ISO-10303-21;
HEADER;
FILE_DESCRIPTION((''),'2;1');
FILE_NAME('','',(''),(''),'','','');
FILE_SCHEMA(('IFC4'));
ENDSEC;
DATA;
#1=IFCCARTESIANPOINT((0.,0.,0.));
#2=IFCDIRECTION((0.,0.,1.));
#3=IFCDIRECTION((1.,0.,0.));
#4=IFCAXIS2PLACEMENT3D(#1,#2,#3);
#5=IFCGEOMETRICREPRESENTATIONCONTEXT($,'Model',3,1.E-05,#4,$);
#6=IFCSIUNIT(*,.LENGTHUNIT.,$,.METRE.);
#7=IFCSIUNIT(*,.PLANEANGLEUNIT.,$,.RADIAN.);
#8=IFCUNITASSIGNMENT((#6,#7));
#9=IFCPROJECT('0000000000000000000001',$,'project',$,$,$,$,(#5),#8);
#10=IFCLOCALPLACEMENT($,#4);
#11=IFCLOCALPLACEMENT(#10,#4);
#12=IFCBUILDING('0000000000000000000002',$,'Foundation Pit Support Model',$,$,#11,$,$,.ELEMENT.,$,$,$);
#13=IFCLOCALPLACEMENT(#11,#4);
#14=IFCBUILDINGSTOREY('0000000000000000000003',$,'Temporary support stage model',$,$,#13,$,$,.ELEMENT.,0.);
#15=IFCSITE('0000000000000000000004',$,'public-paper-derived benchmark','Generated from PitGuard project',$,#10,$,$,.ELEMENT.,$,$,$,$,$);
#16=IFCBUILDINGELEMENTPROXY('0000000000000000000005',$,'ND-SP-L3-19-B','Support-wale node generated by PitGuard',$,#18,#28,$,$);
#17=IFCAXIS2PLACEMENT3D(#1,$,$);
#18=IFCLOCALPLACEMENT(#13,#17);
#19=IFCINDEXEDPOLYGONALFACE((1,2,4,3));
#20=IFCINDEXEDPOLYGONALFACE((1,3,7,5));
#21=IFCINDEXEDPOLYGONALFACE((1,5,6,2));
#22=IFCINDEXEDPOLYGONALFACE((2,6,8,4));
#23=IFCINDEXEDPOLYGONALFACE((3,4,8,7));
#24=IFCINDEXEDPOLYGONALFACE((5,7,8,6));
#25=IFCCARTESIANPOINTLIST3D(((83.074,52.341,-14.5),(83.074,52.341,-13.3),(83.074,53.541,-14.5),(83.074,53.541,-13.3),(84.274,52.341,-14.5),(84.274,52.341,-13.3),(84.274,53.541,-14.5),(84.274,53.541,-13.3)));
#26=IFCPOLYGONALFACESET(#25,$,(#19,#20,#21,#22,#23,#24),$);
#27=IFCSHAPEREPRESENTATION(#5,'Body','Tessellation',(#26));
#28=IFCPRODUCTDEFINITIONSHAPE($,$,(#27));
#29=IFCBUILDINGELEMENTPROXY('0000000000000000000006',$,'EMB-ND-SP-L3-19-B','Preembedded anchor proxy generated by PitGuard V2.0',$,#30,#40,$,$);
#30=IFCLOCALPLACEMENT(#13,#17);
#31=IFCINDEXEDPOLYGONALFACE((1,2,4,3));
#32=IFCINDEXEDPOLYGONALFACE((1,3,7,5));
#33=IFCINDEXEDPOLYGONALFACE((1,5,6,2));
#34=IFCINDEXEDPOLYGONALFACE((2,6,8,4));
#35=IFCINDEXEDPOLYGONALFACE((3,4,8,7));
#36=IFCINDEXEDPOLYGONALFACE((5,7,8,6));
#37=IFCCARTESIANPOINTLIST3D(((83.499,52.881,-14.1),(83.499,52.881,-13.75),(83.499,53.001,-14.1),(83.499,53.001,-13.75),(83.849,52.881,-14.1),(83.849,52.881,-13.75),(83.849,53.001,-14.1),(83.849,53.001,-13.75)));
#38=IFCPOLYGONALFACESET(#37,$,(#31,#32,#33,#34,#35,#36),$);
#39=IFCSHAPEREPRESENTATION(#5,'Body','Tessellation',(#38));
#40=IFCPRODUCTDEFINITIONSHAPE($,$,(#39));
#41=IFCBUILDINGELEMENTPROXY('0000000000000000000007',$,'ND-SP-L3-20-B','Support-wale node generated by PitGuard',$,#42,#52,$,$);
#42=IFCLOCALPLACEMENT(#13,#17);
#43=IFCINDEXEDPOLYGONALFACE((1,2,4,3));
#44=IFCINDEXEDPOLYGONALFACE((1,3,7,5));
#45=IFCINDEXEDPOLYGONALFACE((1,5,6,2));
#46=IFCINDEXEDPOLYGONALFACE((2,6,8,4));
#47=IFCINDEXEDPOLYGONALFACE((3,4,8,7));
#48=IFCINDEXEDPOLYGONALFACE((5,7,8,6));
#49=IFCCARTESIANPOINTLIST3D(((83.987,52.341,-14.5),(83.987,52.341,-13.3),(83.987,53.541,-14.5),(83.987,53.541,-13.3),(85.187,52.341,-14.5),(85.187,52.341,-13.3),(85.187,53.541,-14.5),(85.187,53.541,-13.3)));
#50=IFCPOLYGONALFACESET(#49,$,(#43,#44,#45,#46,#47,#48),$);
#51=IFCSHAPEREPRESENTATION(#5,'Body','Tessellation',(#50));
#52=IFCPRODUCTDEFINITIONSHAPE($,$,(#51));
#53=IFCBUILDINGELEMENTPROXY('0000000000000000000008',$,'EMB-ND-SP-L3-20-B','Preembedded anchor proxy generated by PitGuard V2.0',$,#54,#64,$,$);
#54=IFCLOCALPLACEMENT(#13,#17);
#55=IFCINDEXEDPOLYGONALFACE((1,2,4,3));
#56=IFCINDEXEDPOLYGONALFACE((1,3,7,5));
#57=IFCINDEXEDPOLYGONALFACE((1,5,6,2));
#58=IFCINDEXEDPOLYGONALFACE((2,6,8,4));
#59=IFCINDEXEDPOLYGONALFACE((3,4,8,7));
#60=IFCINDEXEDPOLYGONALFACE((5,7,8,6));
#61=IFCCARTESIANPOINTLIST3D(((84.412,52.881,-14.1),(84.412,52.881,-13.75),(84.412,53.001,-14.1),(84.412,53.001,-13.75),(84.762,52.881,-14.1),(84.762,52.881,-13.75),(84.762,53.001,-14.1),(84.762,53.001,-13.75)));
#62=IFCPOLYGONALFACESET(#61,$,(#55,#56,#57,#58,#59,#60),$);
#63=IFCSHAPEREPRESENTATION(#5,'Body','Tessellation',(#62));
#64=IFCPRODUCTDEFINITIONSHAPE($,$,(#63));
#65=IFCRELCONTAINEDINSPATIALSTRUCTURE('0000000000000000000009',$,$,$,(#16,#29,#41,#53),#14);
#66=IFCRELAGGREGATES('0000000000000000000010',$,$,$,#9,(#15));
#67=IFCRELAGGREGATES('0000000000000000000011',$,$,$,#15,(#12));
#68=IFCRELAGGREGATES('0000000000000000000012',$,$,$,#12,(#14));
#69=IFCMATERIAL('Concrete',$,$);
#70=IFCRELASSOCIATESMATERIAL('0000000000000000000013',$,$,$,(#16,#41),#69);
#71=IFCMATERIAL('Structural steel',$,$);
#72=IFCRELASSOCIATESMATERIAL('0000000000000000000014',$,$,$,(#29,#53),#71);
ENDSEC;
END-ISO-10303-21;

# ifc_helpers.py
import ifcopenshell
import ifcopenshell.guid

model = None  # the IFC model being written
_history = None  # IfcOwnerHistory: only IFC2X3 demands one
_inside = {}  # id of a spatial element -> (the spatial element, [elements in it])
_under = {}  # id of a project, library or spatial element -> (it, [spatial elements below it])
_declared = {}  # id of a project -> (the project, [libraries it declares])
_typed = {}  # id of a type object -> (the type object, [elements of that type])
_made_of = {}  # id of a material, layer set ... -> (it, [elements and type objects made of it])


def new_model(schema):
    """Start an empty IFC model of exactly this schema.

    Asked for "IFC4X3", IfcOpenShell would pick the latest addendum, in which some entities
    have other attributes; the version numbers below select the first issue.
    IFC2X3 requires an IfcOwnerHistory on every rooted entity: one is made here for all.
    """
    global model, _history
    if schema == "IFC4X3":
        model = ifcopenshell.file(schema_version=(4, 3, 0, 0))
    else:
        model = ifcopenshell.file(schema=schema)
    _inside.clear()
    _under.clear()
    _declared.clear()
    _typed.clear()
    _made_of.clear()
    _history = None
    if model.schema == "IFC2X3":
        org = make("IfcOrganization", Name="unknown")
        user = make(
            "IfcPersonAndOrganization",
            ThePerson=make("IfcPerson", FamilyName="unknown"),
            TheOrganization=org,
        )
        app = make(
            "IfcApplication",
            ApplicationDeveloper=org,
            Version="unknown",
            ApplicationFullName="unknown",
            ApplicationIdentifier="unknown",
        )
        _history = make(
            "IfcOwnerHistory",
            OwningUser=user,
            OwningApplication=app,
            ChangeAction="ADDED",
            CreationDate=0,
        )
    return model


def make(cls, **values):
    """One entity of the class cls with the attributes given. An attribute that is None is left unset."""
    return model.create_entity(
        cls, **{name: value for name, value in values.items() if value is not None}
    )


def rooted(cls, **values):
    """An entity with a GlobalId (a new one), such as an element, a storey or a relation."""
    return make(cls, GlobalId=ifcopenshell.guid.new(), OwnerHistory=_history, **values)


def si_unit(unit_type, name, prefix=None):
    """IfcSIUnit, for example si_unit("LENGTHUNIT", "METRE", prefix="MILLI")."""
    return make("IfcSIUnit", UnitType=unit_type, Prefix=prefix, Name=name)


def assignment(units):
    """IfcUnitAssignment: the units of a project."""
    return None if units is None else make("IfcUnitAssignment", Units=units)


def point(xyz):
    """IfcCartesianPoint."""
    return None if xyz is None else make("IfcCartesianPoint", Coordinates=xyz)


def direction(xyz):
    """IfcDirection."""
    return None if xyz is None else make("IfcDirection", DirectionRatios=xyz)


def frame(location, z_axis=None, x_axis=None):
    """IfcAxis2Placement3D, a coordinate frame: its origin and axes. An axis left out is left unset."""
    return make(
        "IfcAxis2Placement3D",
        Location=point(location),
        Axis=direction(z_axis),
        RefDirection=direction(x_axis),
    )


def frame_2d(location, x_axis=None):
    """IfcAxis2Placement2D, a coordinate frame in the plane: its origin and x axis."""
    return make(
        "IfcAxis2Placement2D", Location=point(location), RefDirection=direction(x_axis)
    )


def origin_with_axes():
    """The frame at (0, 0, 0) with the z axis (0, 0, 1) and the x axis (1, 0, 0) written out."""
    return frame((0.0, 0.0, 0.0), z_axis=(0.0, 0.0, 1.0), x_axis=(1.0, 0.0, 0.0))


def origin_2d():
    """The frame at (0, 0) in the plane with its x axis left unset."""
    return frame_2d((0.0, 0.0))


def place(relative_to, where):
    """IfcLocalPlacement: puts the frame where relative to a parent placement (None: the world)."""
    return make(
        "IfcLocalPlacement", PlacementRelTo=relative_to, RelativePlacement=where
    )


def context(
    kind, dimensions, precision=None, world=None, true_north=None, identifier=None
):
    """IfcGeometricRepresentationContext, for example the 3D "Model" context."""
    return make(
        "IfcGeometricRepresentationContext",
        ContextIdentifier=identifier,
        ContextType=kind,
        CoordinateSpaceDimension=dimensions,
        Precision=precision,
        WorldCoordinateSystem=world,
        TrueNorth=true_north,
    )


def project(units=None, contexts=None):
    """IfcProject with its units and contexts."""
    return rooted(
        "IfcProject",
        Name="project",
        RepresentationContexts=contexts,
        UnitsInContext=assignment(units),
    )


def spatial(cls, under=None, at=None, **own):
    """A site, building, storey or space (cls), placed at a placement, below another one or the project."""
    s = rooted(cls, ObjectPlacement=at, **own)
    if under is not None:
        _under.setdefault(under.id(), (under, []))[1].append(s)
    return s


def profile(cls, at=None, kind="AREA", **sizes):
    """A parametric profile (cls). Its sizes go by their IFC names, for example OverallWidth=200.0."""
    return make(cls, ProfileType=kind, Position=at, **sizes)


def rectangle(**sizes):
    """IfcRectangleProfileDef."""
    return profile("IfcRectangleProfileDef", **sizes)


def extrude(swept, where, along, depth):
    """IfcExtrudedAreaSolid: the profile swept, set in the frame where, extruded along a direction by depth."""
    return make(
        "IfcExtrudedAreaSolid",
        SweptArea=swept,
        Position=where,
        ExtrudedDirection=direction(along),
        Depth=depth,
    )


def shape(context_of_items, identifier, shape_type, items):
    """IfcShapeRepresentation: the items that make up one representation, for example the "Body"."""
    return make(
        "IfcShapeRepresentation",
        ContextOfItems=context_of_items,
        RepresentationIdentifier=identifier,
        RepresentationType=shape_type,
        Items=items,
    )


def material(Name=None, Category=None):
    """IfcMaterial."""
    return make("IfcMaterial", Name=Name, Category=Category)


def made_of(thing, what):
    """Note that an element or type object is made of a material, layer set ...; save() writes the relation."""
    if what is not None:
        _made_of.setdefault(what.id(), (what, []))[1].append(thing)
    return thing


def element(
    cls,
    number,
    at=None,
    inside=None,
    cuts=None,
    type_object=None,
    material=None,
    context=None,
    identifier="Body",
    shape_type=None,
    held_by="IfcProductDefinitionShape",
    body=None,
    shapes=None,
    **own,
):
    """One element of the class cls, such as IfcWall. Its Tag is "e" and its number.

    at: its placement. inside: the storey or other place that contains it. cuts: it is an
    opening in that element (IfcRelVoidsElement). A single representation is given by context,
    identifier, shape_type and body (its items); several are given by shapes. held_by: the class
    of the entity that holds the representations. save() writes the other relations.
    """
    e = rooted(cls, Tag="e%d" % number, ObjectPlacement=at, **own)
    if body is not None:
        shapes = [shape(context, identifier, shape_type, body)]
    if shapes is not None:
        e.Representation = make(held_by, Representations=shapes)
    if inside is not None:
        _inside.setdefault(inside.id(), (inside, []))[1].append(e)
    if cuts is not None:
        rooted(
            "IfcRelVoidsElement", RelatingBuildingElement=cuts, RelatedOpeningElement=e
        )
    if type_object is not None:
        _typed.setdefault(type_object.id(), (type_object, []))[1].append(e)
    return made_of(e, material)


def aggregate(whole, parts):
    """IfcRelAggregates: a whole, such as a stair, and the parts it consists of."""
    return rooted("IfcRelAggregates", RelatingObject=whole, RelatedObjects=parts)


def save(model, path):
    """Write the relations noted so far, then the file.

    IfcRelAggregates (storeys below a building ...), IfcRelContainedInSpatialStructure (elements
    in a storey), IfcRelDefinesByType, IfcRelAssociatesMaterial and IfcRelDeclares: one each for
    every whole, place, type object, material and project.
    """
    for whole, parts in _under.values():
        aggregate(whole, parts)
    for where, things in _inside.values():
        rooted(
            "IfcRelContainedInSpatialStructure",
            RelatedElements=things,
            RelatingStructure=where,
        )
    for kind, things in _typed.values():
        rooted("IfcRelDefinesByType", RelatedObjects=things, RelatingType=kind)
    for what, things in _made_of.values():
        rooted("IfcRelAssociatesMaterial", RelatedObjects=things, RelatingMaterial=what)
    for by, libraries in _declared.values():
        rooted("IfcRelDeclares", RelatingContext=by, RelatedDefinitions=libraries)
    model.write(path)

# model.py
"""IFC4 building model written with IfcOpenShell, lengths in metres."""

from ifc_helpers import new_model, si_unit, frame, origin_with_axes, origin_2d, place, context, project, spatial, rectangle, extrude, material, element, save


model = new_model("IFC4")

# Units and contexts
model_context = context("Model", 3, precision=1e-05, world=origin_with_axes())
ifc_project = project(units=[si_unit("LENGTHUNIT", "METRE"), si_unit("PLANEANGLEUNIT", "RADIAN")], contexts=[model_context])

# Site, building, storey
site_placement = place(None, origin_with_axes())
site = spatial("IfcSite", under=ifc_project, at=site_placement, Name="public-paper-derived benchmark", Description="Generated from PitGuard project", CompositionType="ELEMENT")
building_placement = place(site_placement, origin_with_axes())
building = spatial("IfcBuilding", under=site, at=building_placement, Name="Foundation Pit Support Model", CompositionType="ELEMENT")
storey_placement = place(building_placement, origin_with_axes())
storey = spatial("IfcBuildingStorey", under=building, at=storey_placement, Name="Temporary support stage model", CompositionType="ELEMENT", Elevation=0.0)

# Shared definitions
ifc_material_1 = material(Name="Structural steel")

# Shared definitions
ifc_material_2 = material(Name="Concrete")

# Building element proxies
proxy_1_placement = place(storey_placement, frame((83.674, 52.941, -14.5), z_axis=(0.0, 0.0, 1.0), x_axis=(1.0, 0.0, 0.0)))
element("IfcBuildingElementProxy", 1, at=proxy_1_placement, inside=storey, material=ifc_material_2, Name="ND-SP-L3-19-B", Description="Support-wale node generated by PitGuard", context=model_context, shape_type="SweptSolid", body=[
    extrude(rectangle(XDim=1.2, YDim=1.2, at=origin_2d()), origin_with_axes(), (0.0, 0.0, 1.0), 1.2),
])
proxy_2_placement = place(storey_placement, frame((83.674, 52.941, -14.1), z_axis=(0.0, 0.0, 1.0), x_axis=(1.0, 0.0, 0.0)))
element("IfcBuildingElementProxy", 2, at=proxy_2_placement, inside=storey, material=ifc_material_1, Name="EMB-ND-SP-L3-19-B", Description="Preembedded anchor proxy generated by PitGuard V2.0", context=model_context, shape_type="SweptSolid", body=[
    extrude(rectangle(XDim=0.35, YDim=0.12, at=origin_2d()), origin_with_axes(), (0.0, 0.0, 1.0), 0.35),
])
proxy_3_placement = place(storey_placement, frame((84.587, 52.941, -14.5), z_axis=(0.0, 0.0, 1.0), x_axis=(1.0, 0.0, 0.0)))
element("IfcBuildingElementProxy", 3, at=proxy_3_placement, inside=storey, material=ifc_material_2, Name="ND-SP-L3-20-B", Description="Support-wale node generated by PitGuard", context=model_context, shape_type="SweptSolid", body=[
    extrude(rectangle(XDim=1.2, YDim=1.2, at=origin_2d()), origin_with_axes(), (0.0, 0.0, 1.0), 1.2),
])
proxy_4_placement = place(storey_placement, frame((84.587, 52.941, -14.1), z_axis=(0.0, 0.0, 1.0), x_axis=(1.0, 0.0, 0.0)))
element("IfcBuildingElementProxy", 4, at=proxy_4_placement, inside=storey, material=ifc_material_1, Name="EMB-ND-SP-L3-20-B", Description="Preembedded anchor proxy generated by PitGuard V2.0", context=model_context, shape_type="SweptSolid", body=[
    extrude(rectangle(XDim=0.35, YDim=0.12, at=origin_2d()), origin_with_axes(), (0.0, 0.0, 1.0), 0.35),
])

save(model, "model.ifc")
